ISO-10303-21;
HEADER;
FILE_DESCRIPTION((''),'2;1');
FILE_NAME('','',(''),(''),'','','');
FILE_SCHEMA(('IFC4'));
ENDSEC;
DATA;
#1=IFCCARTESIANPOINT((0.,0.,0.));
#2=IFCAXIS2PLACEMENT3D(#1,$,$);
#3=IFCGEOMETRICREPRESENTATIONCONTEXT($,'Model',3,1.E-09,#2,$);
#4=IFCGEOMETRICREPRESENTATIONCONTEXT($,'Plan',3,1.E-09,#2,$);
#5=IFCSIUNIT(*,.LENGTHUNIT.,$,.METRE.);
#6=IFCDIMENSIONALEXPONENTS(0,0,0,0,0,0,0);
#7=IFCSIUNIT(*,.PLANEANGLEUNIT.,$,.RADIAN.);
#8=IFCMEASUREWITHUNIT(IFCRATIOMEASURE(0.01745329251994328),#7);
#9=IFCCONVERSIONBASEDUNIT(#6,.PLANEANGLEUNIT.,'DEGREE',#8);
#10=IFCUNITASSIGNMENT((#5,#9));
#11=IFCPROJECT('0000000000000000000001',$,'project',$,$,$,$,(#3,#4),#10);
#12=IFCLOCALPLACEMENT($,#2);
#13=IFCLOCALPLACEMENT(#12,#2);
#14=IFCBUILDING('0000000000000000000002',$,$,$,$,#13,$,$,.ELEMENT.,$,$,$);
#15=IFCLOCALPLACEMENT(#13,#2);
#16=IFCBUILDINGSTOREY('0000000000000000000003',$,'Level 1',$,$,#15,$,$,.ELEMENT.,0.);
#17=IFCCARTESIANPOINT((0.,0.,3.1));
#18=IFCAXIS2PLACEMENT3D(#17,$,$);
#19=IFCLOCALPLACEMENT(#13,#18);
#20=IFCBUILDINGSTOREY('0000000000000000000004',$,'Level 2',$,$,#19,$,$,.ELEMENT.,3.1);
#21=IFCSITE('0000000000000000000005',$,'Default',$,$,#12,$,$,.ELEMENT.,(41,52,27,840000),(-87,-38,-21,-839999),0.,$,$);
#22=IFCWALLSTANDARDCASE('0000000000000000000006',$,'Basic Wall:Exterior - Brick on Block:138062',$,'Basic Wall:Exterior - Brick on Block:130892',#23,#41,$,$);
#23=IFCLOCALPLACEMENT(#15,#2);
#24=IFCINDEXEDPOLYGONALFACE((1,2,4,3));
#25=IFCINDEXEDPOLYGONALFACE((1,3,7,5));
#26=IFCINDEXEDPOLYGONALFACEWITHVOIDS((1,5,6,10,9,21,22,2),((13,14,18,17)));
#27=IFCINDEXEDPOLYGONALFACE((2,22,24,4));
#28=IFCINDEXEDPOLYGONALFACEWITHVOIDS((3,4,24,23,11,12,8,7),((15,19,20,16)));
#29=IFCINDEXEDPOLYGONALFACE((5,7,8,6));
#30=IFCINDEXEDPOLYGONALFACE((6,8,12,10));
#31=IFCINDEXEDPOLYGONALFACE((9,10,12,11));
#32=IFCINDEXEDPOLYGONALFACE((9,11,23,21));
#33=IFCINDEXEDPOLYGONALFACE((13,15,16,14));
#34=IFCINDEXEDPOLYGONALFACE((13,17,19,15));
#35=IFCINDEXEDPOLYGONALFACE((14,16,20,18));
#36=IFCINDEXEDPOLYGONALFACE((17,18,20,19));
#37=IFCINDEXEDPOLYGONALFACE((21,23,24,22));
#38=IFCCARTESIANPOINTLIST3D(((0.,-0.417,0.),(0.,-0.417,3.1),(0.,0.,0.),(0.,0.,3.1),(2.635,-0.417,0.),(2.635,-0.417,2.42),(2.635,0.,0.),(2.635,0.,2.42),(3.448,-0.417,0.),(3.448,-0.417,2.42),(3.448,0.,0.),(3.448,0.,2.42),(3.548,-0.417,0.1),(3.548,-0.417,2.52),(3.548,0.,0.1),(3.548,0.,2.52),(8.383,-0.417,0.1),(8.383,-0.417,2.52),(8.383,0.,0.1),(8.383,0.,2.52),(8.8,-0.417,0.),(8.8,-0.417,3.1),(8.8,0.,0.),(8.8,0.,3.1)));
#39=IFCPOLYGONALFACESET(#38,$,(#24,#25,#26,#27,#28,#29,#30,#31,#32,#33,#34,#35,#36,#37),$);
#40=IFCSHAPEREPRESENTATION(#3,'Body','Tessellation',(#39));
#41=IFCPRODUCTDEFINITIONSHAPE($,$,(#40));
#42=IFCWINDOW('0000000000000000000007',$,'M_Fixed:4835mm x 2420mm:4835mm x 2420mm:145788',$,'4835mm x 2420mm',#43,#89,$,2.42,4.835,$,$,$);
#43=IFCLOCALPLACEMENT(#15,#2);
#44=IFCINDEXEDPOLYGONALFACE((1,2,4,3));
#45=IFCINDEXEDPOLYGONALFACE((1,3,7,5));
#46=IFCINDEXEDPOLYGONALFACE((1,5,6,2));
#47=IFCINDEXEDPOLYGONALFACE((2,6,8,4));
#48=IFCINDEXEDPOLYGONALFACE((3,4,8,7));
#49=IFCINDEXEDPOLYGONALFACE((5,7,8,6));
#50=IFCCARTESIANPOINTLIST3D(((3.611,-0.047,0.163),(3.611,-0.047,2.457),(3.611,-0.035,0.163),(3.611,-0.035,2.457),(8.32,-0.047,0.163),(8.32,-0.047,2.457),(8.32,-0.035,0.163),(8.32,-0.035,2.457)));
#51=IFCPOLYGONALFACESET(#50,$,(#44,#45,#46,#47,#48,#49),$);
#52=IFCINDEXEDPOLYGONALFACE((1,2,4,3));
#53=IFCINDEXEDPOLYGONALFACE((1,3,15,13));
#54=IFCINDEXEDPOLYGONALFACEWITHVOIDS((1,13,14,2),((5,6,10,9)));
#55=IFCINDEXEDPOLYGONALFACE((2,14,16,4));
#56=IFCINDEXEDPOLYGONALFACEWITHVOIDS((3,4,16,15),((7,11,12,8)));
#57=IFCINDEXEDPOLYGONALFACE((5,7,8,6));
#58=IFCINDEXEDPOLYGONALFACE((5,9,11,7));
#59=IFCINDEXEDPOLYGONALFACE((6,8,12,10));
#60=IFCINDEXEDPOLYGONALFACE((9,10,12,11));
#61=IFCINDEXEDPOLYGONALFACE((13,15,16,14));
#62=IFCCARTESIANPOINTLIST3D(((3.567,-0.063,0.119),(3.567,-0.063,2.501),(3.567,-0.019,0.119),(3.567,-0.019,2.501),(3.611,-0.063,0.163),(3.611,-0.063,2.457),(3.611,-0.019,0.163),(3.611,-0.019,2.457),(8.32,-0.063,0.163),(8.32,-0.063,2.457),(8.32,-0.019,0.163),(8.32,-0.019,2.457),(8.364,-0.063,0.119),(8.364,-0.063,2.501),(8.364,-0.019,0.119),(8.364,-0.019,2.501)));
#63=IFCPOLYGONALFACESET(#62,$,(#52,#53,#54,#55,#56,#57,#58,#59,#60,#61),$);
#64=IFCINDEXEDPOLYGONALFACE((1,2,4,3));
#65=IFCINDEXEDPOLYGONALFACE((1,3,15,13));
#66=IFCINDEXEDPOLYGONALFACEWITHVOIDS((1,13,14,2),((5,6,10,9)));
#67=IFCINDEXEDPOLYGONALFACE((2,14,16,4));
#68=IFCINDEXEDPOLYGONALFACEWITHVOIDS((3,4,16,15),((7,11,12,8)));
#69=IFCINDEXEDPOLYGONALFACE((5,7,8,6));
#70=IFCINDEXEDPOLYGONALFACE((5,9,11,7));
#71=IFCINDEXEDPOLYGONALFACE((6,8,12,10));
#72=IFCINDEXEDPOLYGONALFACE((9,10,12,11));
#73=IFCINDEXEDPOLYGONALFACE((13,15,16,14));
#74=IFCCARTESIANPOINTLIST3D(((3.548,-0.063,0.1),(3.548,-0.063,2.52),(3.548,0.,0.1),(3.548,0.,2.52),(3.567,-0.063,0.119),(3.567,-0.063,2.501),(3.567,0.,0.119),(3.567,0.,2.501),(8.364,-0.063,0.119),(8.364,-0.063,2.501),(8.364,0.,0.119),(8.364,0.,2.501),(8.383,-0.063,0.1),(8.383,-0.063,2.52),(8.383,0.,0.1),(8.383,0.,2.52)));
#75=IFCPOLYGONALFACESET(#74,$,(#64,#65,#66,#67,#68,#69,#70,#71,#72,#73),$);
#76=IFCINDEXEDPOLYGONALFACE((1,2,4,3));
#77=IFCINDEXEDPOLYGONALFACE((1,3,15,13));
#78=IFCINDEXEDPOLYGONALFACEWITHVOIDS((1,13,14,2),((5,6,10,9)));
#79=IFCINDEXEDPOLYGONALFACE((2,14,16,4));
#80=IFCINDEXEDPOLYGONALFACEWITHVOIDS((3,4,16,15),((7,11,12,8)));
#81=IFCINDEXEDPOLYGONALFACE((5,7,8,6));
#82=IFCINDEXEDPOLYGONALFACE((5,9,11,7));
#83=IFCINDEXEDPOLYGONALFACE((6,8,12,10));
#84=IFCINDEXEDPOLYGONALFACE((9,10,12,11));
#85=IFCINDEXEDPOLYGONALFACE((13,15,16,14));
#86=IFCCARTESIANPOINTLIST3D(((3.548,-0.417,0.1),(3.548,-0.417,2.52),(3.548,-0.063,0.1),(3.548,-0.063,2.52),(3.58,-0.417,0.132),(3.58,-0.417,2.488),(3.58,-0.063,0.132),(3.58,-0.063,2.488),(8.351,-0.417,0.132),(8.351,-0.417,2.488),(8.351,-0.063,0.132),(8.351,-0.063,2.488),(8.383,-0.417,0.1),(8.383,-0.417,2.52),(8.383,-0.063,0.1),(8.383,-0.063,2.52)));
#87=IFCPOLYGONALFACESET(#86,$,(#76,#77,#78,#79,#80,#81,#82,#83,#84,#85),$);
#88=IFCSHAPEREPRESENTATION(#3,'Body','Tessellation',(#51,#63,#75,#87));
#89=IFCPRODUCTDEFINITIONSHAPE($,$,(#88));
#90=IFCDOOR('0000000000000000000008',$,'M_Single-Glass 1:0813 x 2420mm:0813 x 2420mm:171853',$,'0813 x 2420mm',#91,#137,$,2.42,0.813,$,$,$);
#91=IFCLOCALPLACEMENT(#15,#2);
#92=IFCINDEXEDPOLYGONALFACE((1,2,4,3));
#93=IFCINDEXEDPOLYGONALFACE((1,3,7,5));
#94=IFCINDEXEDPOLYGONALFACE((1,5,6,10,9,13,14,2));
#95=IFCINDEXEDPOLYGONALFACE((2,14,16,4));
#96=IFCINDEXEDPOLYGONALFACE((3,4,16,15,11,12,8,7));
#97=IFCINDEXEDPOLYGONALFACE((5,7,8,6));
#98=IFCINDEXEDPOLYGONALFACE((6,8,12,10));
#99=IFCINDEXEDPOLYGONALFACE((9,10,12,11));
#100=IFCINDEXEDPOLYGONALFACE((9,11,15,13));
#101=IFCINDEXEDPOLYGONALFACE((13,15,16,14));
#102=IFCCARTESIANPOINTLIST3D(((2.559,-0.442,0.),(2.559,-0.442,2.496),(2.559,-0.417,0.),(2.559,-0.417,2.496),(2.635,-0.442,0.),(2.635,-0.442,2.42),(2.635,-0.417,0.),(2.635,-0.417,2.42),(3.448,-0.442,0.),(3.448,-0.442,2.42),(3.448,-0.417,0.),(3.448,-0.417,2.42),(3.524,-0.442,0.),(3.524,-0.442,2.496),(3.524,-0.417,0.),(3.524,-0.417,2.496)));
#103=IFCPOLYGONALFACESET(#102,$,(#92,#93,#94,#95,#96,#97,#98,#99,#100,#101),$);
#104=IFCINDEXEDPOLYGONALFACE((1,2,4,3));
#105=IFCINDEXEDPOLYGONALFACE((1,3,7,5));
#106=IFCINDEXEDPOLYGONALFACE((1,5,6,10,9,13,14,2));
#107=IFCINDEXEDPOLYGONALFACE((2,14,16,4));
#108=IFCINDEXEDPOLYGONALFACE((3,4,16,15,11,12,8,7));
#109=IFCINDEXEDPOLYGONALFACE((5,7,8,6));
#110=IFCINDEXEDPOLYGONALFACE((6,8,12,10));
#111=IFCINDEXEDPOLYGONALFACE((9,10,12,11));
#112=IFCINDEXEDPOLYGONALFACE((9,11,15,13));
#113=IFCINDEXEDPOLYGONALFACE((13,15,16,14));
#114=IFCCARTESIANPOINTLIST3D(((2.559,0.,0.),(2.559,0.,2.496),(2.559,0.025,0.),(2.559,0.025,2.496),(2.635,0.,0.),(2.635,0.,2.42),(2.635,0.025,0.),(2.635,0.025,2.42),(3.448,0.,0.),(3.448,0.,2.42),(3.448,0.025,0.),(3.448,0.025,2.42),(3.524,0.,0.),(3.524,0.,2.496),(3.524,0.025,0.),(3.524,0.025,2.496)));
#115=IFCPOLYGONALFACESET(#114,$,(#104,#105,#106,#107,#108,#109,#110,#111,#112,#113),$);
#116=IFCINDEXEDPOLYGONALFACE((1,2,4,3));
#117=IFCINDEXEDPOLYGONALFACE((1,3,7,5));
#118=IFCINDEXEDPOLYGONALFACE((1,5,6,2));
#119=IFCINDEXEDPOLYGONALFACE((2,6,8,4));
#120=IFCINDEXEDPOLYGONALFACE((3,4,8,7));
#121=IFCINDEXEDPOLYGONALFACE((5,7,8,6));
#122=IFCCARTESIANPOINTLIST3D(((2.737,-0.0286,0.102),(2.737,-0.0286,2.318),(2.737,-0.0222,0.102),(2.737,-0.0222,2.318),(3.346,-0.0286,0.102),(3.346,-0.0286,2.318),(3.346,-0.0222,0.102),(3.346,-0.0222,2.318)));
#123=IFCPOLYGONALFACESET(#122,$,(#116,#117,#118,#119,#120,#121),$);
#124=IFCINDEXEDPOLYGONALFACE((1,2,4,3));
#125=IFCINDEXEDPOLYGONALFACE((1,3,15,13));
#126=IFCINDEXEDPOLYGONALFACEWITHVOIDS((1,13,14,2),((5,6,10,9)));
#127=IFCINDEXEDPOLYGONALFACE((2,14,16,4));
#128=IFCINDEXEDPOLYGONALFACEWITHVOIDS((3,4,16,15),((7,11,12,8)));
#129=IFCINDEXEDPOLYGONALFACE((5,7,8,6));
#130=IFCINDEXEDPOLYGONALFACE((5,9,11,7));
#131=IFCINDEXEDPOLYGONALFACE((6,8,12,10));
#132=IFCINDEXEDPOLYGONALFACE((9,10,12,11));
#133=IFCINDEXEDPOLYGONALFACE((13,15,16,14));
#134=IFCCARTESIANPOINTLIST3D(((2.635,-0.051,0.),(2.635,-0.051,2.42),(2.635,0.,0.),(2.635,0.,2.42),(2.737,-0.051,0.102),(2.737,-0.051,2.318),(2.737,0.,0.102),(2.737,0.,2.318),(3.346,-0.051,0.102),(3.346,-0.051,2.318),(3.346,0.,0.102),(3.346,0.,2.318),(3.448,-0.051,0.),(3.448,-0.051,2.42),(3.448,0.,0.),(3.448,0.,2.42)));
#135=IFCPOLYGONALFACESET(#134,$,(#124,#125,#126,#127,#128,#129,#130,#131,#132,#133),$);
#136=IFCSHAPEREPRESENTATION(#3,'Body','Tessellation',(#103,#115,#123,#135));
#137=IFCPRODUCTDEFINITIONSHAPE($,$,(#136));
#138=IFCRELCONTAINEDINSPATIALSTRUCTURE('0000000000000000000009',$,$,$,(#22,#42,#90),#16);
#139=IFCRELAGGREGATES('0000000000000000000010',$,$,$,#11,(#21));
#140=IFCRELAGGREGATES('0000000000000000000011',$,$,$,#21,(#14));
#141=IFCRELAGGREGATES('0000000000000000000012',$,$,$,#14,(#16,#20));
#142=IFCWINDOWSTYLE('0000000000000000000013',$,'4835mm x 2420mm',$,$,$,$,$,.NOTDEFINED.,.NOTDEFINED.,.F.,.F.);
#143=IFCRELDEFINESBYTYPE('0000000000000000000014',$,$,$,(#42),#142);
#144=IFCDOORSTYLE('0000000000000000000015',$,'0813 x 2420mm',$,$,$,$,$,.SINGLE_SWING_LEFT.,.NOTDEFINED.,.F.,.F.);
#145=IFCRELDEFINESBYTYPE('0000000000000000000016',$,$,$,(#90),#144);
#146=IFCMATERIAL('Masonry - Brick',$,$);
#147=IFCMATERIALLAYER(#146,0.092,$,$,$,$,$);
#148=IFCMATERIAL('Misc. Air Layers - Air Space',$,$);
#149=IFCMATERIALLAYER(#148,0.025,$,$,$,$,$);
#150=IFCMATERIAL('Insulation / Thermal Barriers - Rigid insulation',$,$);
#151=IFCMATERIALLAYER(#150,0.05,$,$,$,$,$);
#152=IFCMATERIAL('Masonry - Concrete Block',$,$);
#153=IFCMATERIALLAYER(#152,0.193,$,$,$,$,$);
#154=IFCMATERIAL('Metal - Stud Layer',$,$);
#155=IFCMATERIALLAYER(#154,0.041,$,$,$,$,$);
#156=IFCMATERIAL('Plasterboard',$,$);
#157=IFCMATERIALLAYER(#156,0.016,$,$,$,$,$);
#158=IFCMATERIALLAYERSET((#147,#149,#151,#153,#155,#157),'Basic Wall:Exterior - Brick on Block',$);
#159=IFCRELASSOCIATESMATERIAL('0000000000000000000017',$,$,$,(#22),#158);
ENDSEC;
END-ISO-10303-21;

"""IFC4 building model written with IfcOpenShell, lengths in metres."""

from ifc_helpers import new_model, entity, si_unit, converted_unit, frame, frame_2d, origin, origin_2d_with_axis, place, context, project, spatial, polyline, rectangle, outline, extrude, source, transform, mapped, material, layer, layer_set, layer_usage, type_object, type_shapes, element, fill, save


model = new_model("IFC4")

# Units and contexts
model_context = context("Model", 3, precision=1e-09, world=origin())
plan_context = context("Plan", 3, precision=1e-09, world=origin())
ifc_project = project(units=[si_unit("LENGTHUNIT", "METRE"), converted_unit("PLANEANGLEUNIT", "DEGREE", entity("IfcRatioMeasure", 0.01745329251994328), si_unit("PLANEANGLEUNIT", "RADIAN"), dimensions=[0, 0, 0, 0, 0, 0, 0])], contexts=[model_context, plan_context])

# Site, building, storey
site_placement = place(None, origin())
site = spatial("IfcSite", under=ifc_project, at=site_placement, Name="Default", CompositionType="ELEMENT", RefLatitude=(41, 52, 27, 840000), RefLongitude=(-87, -38, -21, -839999), RefElevation=0.0)
building_placement = place(site_placement, origin())
building = spatial("IfcBuilding", under=site, at=building_placement, CompositionType="ELEMENT")
storey_1_placement = place(building_placement, origin())
storey_1 = spatial("IfcBuildingStorey", under=building, at=storey_1_placement, Name="Level 1", CompositionType="ELEMENT", Elevation=0.0)

# Wall, openings, window, door
ifc_material_1 = material(Name="Masonry - Brick")
ifc_layer_1 = layer(ifc_material_1, 0.092)
ifc_material_2 = material(Name="Misc. Air Layers - Air Space")
ifc_layer_2 = layer(ifc_material_2, 0.025)
ifc_material_3 = material(Name="Insulation / Thermal Barriers - Rigid insulation")
ifc_layer_3 = layer(ifc_material_3, 0.05)
ifc_material_4 = material(Name="Masonry - Concrete Block")
ifc_layer_4 = layer(ifc_material_4, 0.193)
ifc_material_5 = material(Name="Metal - Stud Layer")
ifc_layer_5 = layer(ifc_material_5, 0.041)
ifc_material_6 = material(Name="Plasterboard")
ifc_layer_6 = layer(ifc_material_6, 0.016)
ifc_layer_set_1 = layer_set([ifc_layer_1, ifc_layer_2, ifc_layer_3, ifc_layer_4, ifc_layer_5, ifc_layer_6], Name="Basic Wall:Exterior - Brick on Block")
ifc_layer_usage_1 = layer_usage(ifc_layer_set_1, "AXIS2", "NEGATIVE", 0.2085)
wall_1_placement = place(storey_1_placement, frame((0.0, -0.2085, 0.0)))
wall_1 = element("IfcWallStandardCase", 1, at=wall_1_placement, inside=storey_1, material=ifc_layer_usage_1, Name="Basic Wall:Exterior - Brick on Block:138062", ObjectType="Basic Wall:Exterior - Brick on Block:130892", context=model_context, shape_type="SweptSolid", body=[
    extrude(rectangle(XDim=8.8, YDim=0.417, at=frame_2d((4.4, 0.0), x_axis=(-1.0, 0.0))), origin(), (0.0, 0.0, 1.0), 3.1),
])
opening_1_placement = place(wall_1_placement, frame((3.548, -0.2085, 0.1)))
opening_1 = element("IfcOpeningElement", 2, at=opening_1_placement, cuts=wall_1, ObjectType="Opening", context=model_context, shape_type="SweptSolid", body=[
    extrude(rectangle(XDim=2.42, YDim=4.835, at=frame_2d((1.21, 2.4175), x_axis=(1.0, 0.0))), frame((0.0, 0.0, 0.0), z_axis=(0.0, 1.0, 0.0), x_axis=(0.0, 0.0, 1.0)), (0.0, 0.0, 1.0), 0.417),
])
opening_2_placement = place(wall_1_placement, frame((2.635, -0.2085, 0.0)))
opening_2 = element("IfcOpeningElement", 3, at=opening_2_placement, cuts=wall_1, ObjectType="Opening", context=model_context, shape_type="SweptSolid", body=[
    extrude(rectangle(XDim=0.813, YDim=2.42, at=frame_2d((1.21, 0.4065), x_axis=(0.0, -1.0))), frame((0.0, 0.0, 0.0), z_axis=(0.0, 1.0, 0.0), x_axis=(0.0, 0.0, 1.0)), (0.0, 0.0, 1.0), 0.417),
])
window_style_1 = type_object("IfcWindowStyle", Name="4835mm x 2420mm", ConstructionType="NOTDEFINED", OperationType="NOTDEFINED", ParameterTakesPrecedence=False, Sizeable=False)
shared_shape_1 = source(origin(), model_context, "Body", "SweptSolid", [
    extrude(rectangle(XDim=0.012, YDim=4.709, at=origin_2d_with_axis()), frame((2.4175, 0.376, 0.063), z_axis=(0.0, 0.0, 1.0), x_axis=(0.0, -1.0, 0.0)), (0.0, 0.0, 1.0), 2.294),
    extrude(outline(polyline([(-2.3985, -1.191), (2.3985, -1.191), (2.3985, 1.191), (-2.3985, 1.191), (-2.3985, -1.191)]), holes=[polyline([(-2.3545, -1.147), (-2.3545, 1.147), (2.3545, 1.147), (2.3545, -1.147), (-2.3545, -1.147)])]), frame((2.4175, 0.354, 1.21), z_axis=(0.0, 1.0, 0.0), x_axis=(1.0, 0.0, 0.0)), (0.0, 0.0, 1.0), 0.044),
    extrude(outline(polyline([(-2.4175, -1.21), (2.4175, -1.21), (2.4175, 1.21), (-2.4175, 1.21), (-2.4175, -1.21)]), holes=[polyline([(-2.3985, -1.191), (-2.3985, 1.191), (2.3985, 1.191), (2.3985, -1.191), (-2.3985, -1.191)])]), frame((2.4175, 0.354, 1.21), z_axis=(0.0, 1.0, 0.0), x_axis=(1.0, 0.0, 0.0)), (0.0, 0.0, 1.0), 0.063),
    extrude(outline(polyline([(-2.4175, -1.21), (2.4175, -1.21), (2.4175, 1.21), (-2.4175, 1.21), (-2.4175, -1.21)]), holes=[polyline([(-2.3855, -1.178), (-2.3855, 1.178), (2.3855, 1.178), (2.3855, -1.178), (-2.3855, -1.178)])]), frame((2.4175, 0.0, 1.21), z_axis=(0.0, 1.0, 0.0), x_axis=(1.0, 0.0, 0.0)), (0.0, 0.0, 1.0), 0.354),
])
type_shapes(window_style_1, [shared_shape_1])
window_1_placement = place(opening_1_placement, origin())
window_1 = element("IfcWindow", 4, at=window_1_placement, inside=storey_1, type_object=window_style_1, Name="M_Fixed:4835mm x 2420mm:4835mm x 2420mm:145788", ObjectType="4835mm x 2420mm", OverallHeight=2.42, OverallWidth=4.835, context=model_context, shape_type="MappedRepresentation", body=[
    mapped(shared_shape_1, transform((0.0, 0.0, 0.0), scale=1.0)),
])
fill(opening_1, window_1)
door_style_1 = type_object("IfcDoorStyle", Name="0813 x 2420mm", ConstructionType="NOTDEFINED", OperationType="SINGLE_SWING_LEFT", ParameterTakesPrecedence=False, Sizeable=False)
shared_shape_2 = source(origin(), model_context, "Body", "SweptSolid", [
    extrude(outline(polyline([(-0.4065, -1.191), (-0.4065, 1.229), (-0.4825, 1.229), (-0.4825, -1.267), (0.4825, -1.267), (0.4825, 1.229), (0.4065, 1.229), (0.4065, -1.191), (-0.4065, -1.191)])), frame((0.4065, 0.0, 1.229), z_axis=(0.0, 1.0, 0.0), x_axis=(1.0, 0.0, 0.0)), (0.0, 0.0, -1.0), 0.025),
    extrude(outline(polyline([(-0.4065, -1.191), (-0.4065, 1.229), (-0.4825, 1.229), (-0.4825, -1.267), (0.4825, -1.267), (0.4825, 1.229), (0.4065, 1.229), (0.4065, -1.191), (-0.4065, -1.191)])), frame((0.4065, 0.442, 1.229), z_axis=(0.0, 1.0, 0.0), x_axis=(1.0, 0.0, 0.0)), (0.0, 0.0, -1.0), 0.025),
    extrude(rectangle(XDim=0.609, YDim=0.0064, at=origin_2d_with_axis()), frame((0.4065, 0.3916, 0.102)), (0.0, 0.0, 1.0), 2.216),
    extrude(outline(polyline([(-1.21, -0.4065), (1.21, -0.4065), (1.21, 0.4065), (-1.21, 0.4065), (-1.21, -0.4065)]), holes=[polyline([(-1.108, 0.3045), (1.108, 0.3045), (1.108, -0.3045), (-1.108, -0.3045), (-1.108, 0.3045)])]), frame((0.4065, 0.417, 1.21), z_axis=(0.0, -1.0, 0.0), x_axis=(0.0, 0.0, -1.0)), (0.0, 0.0, 1.0), 0.051),
])
type_shapes(door_style_1, [shared_shape_2])
door_1_placement = place(opening_2_placement, origin())
door_1 = element("IfcDoor", 5, at=door_1_placement, inside=storey_1, type_object=door_style_1, Name="M_Single-Glass 1:0813 x 2420mm:0813 x 2420mm:171853", ObjectType="0813 x 2420mm", OverallHeight=2.42, OverallWidth=0.813, context=model_context, shape_type="MappedRepresentation", body=[
    mapped(shared_shape_2, transform((0.0, 0.0, 0.0), scale=1.0)),
])
fill(opening_2, door_1)

# Shared definitions
storey_2_placement = place(building_placement, frame((0.0, 0.0, 3.1)))
storey_2 = spatial("IfcBuildingStorey", under=building, at=storey_2_placement, Name="Level 2", CompositionType="ELEMENT", Elevation=3.1)

save(model, "model.ifc")
